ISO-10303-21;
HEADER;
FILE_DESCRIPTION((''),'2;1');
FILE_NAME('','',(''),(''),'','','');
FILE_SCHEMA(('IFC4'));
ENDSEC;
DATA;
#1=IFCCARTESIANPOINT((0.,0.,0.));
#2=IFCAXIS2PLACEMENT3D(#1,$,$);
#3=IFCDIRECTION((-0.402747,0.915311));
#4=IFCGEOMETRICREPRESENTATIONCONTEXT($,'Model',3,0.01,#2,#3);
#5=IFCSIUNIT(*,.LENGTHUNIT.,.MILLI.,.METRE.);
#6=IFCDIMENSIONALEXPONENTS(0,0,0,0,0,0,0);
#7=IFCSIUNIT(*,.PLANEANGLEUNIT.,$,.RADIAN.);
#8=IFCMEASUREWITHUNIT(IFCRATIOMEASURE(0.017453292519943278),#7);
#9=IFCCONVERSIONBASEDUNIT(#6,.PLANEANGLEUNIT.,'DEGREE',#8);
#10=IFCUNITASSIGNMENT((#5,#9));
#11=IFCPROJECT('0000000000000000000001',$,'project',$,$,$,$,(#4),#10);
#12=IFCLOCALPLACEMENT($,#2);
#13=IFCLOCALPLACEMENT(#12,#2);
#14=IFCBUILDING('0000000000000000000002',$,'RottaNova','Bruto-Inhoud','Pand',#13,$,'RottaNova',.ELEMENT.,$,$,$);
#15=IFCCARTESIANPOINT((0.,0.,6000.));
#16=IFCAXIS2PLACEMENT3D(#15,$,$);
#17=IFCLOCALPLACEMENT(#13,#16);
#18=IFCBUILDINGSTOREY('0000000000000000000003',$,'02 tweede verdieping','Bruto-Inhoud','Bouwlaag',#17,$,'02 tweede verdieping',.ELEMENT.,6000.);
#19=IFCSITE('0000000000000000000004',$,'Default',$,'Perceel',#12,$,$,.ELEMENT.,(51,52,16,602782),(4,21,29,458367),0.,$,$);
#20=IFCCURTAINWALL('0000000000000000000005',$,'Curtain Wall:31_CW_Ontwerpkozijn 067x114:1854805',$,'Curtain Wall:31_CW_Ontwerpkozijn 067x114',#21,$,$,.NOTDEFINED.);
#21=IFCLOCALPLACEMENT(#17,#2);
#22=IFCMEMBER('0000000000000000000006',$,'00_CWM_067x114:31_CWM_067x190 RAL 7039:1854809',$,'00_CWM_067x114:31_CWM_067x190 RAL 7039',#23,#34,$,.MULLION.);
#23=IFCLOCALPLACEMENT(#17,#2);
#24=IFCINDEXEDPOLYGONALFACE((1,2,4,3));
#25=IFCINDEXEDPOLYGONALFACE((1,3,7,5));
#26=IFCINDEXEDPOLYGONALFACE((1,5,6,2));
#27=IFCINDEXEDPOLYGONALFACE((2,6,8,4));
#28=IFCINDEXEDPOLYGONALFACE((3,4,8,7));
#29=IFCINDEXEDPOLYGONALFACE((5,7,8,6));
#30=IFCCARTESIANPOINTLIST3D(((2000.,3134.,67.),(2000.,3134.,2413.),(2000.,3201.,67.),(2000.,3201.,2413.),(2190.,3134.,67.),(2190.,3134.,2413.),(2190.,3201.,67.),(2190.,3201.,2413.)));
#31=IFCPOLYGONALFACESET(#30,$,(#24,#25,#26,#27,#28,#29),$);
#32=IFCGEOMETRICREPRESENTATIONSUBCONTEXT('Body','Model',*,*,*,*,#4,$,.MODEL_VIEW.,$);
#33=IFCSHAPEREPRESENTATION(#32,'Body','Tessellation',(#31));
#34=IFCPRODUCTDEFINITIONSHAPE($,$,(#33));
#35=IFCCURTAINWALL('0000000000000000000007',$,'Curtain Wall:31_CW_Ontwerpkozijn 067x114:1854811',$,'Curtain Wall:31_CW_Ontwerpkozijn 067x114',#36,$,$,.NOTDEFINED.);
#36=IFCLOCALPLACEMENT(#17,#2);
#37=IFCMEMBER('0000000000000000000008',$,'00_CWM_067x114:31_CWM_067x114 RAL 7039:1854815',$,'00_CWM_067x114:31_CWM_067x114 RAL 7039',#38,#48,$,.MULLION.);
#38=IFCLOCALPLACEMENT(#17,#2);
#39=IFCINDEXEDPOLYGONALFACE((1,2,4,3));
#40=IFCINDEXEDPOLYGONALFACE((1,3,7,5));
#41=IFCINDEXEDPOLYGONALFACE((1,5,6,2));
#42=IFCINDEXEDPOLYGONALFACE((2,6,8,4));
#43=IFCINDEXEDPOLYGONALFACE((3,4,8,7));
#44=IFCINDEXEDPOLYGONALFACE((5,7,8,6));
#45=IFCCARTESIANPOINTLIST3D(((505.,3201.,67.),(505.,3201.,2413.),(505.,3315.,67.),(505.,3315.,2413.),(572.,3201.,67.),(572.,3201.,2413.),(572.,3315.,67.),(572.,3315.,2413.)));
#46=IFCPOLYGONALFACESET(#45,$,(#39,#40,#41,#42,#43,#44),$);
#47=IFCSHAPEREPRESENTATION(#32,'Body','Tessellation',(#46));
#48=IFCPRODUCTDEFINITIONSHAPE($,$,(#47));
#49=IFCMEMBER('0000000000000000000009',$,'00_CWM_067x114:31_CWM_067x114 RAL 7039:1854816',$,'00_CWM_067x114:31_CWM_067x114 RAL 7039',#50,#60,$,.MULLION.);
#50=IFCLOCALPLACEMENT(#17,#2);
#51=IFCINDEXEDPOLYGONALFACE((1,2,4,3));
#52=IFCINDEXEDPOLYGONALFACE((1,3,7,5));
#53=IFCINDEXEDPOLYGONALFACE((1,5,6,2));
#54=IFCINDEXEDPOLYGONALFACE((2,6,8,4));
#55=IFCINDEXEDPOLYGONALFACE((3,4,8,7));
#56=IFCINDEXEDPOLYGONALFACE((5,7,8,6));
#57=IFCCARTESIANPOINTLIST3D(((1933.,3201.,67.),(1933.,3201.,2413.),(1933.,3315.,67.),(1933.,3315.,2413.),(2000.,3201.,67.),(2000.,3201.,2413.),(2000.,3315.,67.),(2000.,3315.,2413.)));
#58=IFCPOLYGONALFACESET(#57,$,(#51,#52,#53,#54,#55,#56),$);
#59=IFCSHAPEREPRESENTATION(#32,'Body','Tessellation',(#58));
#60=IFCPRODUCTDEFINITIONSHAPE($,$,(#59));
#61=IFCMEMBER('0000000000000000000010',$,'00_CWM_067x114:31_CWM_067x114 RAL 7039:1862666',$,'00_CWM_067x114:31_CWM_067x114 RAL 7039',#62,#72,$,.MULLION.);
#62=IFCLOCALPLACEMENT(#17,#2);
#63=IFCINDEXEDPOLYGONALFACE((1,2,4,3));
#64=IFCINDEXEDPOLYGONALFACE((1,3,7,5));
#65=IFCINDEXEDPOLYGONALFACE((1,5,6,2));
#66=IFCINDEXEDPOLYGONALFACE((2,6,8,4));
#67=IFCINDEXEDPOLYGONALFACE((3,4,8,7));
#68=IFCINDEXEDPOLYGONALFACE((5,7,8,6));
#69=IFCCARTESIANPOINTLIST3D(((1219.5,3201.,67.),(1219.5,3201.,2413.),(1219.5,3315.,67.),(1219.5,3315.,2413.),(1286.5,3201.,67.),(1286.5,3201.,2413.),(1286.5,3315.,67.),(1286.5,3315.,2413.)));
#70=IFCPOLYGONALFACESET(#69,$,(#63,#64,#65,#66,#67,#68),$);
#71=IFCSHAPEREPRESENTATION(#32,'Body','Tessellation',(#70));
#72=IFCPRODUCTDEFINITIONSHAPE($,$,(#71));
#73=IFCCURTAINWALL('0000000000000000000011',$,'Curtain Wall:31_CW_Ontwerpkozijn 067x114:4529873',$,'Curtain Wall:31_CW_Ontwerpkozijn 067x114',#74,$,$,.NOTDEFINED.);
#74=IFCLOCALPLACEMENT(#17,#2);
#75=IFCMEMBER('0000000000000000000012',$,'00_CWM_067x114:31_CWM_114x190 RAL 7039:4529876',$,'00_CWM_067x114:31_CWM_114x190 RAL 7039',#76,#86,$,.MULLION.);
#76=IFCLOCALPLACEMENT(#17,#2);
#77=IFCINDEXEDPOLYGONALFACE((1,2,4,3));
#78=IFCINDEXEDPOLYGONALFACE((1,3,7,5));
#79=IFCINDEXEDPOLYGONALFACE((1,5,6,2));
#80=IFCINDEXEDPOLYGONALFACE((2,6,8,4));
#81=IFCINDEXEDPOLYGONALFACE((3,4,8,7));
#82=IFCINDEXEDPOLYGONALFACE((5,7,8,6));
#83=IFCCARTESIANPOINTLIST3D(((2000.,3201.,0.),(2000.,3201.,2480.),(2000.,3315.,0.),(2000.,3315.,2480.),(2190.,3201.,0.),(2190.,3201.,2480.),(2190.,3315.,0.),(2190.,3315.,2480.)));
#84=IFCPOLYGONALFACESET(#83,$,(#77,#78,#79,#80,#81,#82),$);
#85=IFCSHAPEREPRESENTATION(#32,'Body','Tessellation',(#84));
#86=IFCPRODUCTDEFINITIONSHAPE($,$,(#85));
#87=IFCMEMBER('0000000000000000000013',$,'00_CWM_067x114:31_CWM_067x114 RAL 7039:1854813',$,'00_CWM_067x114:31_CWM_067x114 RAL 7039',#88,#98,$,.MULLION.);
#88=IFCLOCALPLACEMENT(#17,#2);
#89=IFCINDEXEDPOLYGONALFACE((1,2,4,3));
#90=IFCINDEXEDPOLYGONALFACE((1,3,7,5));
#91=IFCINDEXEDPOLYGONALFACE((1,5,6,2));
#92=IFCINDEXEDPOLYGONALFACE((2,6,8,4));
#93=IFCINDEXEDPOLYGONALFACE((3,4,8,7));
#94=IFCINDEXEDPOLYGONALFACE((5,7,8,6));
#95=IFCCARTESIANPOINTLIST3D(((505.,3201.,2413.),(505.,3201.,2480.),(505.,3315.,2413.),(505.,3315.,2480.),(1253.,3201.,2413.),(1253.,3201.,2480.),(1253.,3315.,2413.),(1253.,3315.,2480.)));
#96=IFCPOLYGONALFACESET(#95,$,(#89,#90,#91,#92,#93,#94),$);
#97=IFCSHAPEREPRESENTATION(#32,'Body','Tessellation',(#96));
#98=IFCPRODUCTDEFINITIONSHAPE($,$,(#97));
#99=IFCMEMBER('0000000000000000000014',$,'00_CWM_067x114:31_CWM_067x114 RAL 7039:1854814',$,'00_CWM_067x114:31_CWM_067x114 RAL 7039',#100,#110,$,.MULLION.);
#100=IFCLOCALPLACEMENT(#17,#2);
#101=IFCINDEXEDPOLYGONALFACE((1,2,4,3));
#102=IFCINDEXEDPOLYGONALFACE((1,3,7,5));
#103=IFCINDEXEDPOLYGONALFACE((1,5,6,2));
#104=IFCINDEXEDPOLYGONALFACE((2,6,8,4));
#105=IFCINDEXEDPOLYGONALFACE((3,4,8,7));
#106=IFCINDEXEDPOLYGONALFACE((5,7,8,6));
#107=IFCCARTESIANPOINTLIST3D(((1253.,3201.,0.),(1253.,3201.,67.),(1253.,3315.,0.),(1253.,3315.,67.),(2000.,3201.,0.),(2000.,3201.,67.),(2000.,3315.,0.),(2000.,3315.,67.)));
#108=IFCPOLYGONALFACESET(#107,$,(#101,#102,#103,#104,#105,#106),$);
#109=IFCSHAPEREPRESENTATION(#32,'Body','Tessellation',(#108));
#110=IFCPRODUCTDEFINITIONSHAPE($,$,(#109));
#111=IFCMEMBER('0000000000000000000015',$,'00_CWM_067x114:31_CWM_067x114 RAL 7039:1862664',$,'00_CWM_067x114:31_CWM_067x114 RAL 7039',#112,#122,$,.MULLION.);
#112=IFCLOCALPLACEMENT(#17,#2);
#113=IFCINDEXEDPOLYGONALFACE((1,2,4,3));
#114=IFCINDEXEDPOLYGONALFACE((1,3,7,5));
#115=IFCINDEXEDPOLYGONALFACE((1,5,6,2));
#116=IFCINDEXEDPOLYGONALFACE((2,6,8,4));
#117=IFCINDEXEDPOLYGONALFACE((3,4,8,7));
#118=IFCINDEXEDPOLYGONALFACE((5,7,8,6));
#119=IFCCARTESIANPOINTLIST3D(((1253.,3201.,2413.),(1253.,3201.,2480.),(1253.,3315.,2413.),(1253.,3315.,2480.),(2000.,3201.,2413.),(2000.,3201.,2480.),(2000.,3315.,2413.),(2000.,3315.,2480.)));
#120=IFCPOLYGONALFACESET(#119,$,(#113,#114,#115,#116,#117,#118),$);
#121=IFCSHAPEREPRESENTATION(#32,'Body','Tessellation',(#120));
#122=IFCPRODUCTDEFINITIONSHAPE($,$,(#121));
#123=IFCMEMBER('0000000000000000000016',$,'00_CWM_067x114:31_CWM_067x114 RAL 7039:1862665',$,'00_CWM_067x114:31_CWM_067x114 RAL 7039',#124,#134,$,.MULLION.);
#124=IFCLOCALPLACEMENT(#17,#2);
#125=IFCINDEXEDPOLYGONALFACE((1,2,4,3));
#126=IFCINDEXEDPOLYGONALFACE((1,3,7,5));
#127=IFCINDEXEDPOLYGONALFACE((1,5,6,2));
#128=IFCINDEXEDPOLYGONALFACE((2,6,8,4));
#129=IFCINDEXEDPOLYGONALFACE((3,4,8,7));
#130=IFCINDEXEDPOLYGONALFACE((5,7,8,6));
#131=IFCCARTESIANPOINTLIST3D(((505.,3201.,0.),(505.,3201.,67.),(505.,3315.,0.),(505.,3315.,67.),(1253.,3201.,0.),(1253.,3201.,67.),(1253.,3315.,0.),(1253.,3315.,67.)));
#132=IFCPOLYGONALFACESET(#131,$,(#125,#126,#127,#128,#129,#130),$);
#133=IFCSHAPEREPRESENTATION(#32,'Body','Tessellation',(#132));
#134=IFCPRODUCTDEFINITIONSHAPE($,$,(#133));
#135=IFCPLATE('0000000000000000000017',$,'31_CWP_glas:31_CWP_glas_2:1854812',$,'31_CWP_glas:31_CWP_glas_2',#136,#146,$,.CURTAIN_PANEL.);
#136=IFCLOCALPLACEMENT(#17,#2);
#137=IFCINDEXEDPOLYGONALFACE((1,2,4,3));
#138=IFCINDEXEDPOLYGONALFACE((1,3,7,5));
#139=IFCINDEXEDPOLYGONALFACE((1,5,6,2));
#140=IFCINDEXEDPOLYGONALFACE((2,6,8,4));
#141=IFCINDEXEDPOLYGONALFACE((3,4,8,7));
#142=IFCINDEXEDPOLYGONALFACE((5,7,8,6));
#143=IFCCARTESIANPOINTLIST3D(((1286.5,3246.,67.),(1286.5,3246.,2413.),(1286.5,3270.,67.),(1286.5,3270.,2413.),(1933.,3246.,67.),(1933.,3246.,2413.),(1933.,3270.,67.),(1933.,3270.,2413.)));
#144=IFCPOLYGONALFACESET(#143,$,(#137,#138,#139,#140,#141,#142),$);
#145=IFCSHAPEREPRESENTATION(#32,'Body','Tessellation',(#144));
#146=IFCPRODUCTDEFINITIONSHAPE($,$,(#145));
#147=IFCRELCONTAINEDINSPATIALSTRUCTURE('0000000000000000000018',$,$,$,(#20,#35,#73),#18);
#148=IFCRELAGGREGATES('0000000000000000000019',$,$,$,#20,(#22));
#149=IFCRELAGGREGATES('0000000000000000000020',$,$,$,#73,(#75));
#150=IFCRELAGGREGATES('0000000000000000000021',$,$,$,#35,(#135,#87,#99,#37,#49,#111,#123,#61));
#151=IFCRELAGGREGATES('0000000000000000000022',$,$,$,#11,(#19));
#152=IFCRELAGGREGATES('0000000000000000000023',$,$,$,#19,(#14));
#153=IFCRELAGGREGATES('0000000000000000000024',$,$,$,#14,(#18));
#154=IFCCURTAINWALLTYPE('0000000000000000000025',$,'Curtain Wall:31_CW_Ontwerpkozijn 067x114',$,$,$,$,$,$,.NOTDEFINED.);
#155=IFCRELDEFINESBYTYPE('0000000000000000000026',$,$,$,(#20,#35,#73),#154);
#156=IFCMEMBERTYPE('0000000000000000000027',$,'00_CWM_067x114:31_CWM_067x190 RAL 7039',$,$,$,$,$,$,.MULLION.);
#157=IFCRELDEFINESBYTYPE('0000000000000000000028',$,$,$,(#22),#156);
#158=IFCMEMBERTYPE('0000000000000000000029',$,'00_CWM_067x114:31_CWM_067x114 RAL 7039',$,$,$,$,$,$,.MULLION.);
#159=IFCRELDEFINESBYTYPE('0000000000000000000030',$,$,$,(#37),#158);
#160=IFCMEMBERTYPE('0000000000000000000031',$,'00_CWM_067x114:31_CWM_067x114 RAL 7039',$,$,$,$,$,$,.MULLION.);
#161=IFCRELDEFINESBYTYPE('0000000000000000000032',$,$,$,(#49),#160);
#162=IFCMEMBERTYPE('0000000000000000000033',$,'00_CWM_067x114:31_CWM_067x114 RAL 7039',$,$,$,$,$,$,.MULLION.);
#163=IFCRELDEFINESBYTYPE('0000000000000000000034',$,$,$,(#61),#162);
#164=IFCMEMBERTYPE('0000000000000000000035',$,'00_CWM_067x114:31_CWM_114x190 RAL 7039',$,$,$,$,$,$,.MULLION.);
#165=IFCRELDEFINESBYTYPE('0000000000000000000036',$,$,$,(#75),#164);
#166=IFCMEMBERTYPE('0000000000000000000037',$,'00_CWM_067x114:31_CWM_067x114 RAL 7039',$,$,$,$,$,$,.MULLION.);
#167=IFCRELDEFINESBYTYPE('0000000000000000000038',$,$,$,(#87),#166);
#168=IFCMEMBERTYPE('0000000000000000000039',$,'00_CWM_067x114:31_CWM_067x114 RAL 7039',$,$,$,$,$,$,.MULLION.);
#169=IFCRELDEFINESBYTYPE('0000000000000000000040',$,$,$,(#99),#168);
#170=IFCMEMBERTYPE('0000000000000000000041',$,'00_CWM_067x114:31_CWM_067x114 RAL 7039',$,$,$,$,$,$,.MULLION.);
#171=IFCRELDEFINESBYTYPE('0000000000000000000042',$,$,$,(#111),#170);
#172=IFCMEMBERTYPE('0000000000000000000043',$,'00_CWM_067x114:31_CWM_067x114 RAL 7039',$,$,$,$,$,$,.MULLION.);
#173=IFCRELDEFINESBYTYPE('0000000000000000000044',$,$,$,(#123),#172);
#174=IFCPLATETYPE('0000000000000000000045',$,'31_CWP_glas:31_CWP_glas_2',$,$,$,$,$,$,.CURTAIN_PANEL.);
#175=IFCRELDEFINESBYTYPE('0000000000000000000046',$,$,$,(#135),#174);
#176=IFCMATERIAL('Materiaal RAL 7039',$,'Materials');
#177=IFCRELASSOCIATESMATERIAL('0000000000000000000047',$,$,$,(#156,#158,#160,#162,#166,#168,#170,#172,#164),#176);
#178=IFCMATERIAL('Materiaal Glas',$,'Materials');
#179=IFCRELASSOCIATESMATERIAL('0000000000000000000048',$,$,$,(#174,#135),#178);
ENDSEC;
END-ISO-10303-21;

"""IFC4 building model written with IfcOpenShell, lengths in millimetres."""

from ifc_helpers import new_model, entity, si_unit, converted_unit, direction, frame, frame_2d, origin, origin_2d_with_axis, place, context, subcontext, project, spatial, rectangle, extrude, source, transform, mapped, material, material_profile, profile_set, type_object, type_shapes, element, aggregate, save


model = new_model("IFC4")

# Units and contexts
model_context = context("Model", 3, precision=0.01, world=origin(), true_north=direction((-0.402747, 0.915311)))
body_context = subcontext(model_context, "Body", "Model", "MODEL_VIEW")
ifc_project = project(units=[si_unit("LENGTHUNIT", "METRE", prefix="MILLI"), converted_unit("PLANEANGLEUNIT", "DEGREE", entity("IfcRatioMeasure", 0.017453292519943278), si_unit("PLANEANGLEUNIT", "RADIAN"), dimensions=[0, 0, 0, 0, 0, 0, 0])], contexts=[model_context])

# Site, building, storey
site_placement = place(None, origin())
site = spatial("IfcSite", under=ifc_project, at=site_placement, Name="Default", ObjectType="Perceel", CompositionType="ELEMENT", RefLatitude=(51, 52, 16, 602782), RefLongitude=(4, 21, 29, 458367), RefElevation=0.0)
building_placement = place(site_placement, origin())
building = spatial("IfcBuilding", under=site, at=building_placement, Name="RottaNova", Description="Bruto-Inhoud", ObjectType="Pand", LongName="RottaNova", CompositionType="ELEMENT")
storey_placement = place(building_placement, frame((0.0, 0.0, 6000.0)))
storey = spatial("IfcBuildingStorey", under=building, at=storey_placement, Name="02 tweede verdieping", Description="Bruto-Inhoud", ObjectType="Bouwlaag", LongName="02 tweede verdieping", CompositionType="ELEMENT", Elevation=6000.0)

# Curtain wall, member
curtain_wall_type = type_object("IfcCurtainWallType", Name="Curtain Wall:31_CW_Ontwerpkozijn 067x114", PredefinedType="NOTDEFINED")
curtain_wall_1_placement = place(storey_placement, frame((0.0, 0.0, -6000.0)))
curtain_wall_1 = element("IfcCurtainWall", 1, at=curtain_wall_1_placement, inside=storey, type_object=curtain_wall_type, Name="Curtain Wall:31_CW_Ontwerpkozijn 067x114:1854805", ObjectType="Curtain Wall:31_CW_Ontwerpkozijn 067x114", PredefinedType="NOTDEFINED")
ifc_material_1 = material(Name="Materiaal RAL 7039", Category="Materials")
ifc_material_profile_1 = material_profile(ifc_material_1, rectangle(XDim=190.0, YDim=67.0, at=origin_2d_with_axis()), Name="31_CWM_067x190 RAL 7039")
ifc_profile_set_1 = profile_set([ifc_material_profile_1], Name="31_CWM_067x190 RAL 7039")
member_type_1 = type_object("IfcMemberType", Name="00_CWM_067x114:31_CWM_067x190 RAL 7039", PredefinedType="MULLION", material=ifc_profile_set_1)
shared_shape_1 = source(origin(), body_context, "Body", "SweptSolid", [
    extrude(rectangle(XDim=190.0, YDim=67.0, at=origin_2d_with_axis()), frame((-33.5, -95.0, -2346.0), z_axis=(0.0, 0.0, 1.0), x_axis=(0.0, -1.0, 0.0)), (0.0, 0.0, 1.0), 2346.0),
])
type_shapes(member_type_1, [shared_shape_1])
member_1_placement = place(curtain_wall_1_placement, frame((2190.0, 3201.0, 6067.0), z_axis=(0.0, 0.0, -1.0), x_axis=(0.0, 1.0, 0.0)))
member_1 = element("IfcMember", 2, at=member_1_placement, type_object=member_type_1, Name="00_CWM_067x114:31_CWM_067x190 RAL 7039:1854809", ObjectType="00_CWM_067x114:31_CWM_067x190 RAL 7039", PredefinedType="MULLION", context=body_context, shape_type="MappedRepresentation", body=[
    mapped(shared_shape_1, transform((0.0, 0.0, 0.0), scale=1.0)),
])
aggregate(curtain_wall_1, [member_1])

# Curtain wall, members
curtain_wall_2_placement = place(storey_placement, frame((0.0, 0.0, -6000.0)))
curtain_wall_2 = element("IfcCurtainWall", 3, at=curtain_wall_2_placement, inside=storey, type_object=curtain_wall_type, Name="Curtain Wall:31_CW_Ontwerpkozijn 067x114:1854811", ObjectType="Curtain Wall:31_CW_Ontwerpkozijn 067x114", PredefinedType="NOTDEFINED")
ifc_material_profile_2 = material_profile(ifc_material_1, rectangle(XDim=114.0, YDim=67.0, at=origin_2d_with_axis()), Name="31_CWM_067x114 RAL 7039")
ifc_profile_set_2 = profile_set([ifc_material_profile_2], Name="31_CWM_067x114 RAL 7039")
member_type_2 = type_object("IfcMemberType", Name="00_CWM_067x114:31_CWM_067x114 RAL 7039", PredefinedType="MULLION", material=ifc_profile_set_2)
shared_shape_2 = source(origin(), body_context, "Body", "SweptSolid", [
    extrude(rectangle(XDim=114.0, YDim=67.0, at=frame_2d((0.0, 0.0), x_axis=(1.0, 0.0))), frame((-33.5, -57.0, -2346.0), z_axis=(0.0, 0.0, 1.0), x_axis=(0.0, -1.0, 0.0)), (0.0, 0.0, 1.0), 2346.0),
])
type_shapes(member_type_2, [shared_shape_2])
member_2_placement = place(curtain_wall_2_placement, frame((505.0, 3315.0, 6067.0), z_axis=(0.0, 0.0, -1.0), x_axis=(-1.0, 0.0, 0.0)))
member_2 = element("IfcMember", 4, at=member_2_placement, type_object=member_type_2, Name="00_CWM_067x114:31_CWM_067x114 RAL 7039:1854815", ObjectType="00_CWM_067x114:31_CWM_067x114 RAL 7039", PredefinedType="MULLION", context=body_context, shape_type="MappedRepresentation", body=[
    mapped(shared_shape_2, transform((0.0, 0.0, 0.0), scale=1.0)),
])
member_type_3 = type_object("IfcMemberType", Name="00_CWM_067x114:31_CWM_067x114 RAL 7039", PredefinedType="MULLION", material=ifc_profile_set_2)
shared_shape_3 = source(origin(), body_context, "Body", "SweptSolid", [
    extrude(rectangle(XDim=114.0, YDim=67.0, at=frame_2d((0.0, 0.0), x_axis=(1.0, 0.0))), frame((-33.5, -57.0, -2346.0), z_axis=(0.0, 0.0, 1.0), x_axis=(0.0, -1.0, 0.0)), (0.0, 0.0, 1.0), 2346.0),
])
type_shapes(member_type_3, [shared_shape_3])
member_3_placement = place(curtain_wall_2_placement, frame((2000.0, 3315.0, 8413.0)))
member_3 = element("IfcMember", 5, at=member_3_placement, type_object=member_type_3, Name="00_CWM_067x114:31_CWM_067x114 RAL 7039:1854816", ObjectType="00_CWM_067x114:31_CWM_067x114 RAL 7039", PredefinedType="MULLION", context=body_context, shape_type="MappedRepresentation", body=[
    mapped(shared_shape_3, transform((0.0, 0.0, 0.0), scale=1.0)),
])
member_type_4 = type_object("IfcMemberType", Name="00_CWM_067x114:31_CWM_067x114 RAL 7039", PredefinedType="MULLION", material=ifc_profile_set_2)
shared_shape_4 = source(origin(), body_context, "Body", "SweptSolid", [
    extrude(rectangle(XDim=114.0, YDim=67.0, at=frame_2d((0.0, 0.0), x_axis=(1.0, 0.0))), frame((0.0, -57.0, -2346.0), z_axis=(0.0, 0.0, 1.0), x_axis=(0.0, -1.0, 0.0)), (0.0, 0.0, 1.0), 2346.0),
])
type_shapes(member_type_4, [shared_shape_4])
member_4_placement = place(curtain_wall_2_placement, frame((1253.0, 3315.0, 6067.0), z_axis=(0.0, 0.0, -1.0), x_axis=(-1.0, 0.0, 0.0)))
member_4 = element("IfcMember", 6, at=member_4_placement, type_object=member_type_4, Name="00_CWM_067x114:31_CWM_067x114 RAL 7039:1862666", ObjectType="00_CWM_067x114:31_CWM_067x114 RAL 7039", PredefinedType="MULLION", context=body_context, shape_type="MappedRepresentation", body=[
    mapped(shared_shape_4, transform((0.0, 0.0, 0.0), scale=1.0)),
])

# Curtain wall, member
curtain_wall_3_placement = place(storey_placement, frame((0.0, 0.0, -6000.0)))
curtain_wall_3 = element("IfcCurtainWall", 7, at=curtain_wall_3_placement, inside=storey, type_object=curtain_wall_type, Name="Curtain Wall:31_CW_Ontwerpkozijn 067x114:4529873", ObjectType="Curtain Wall:31_CW_Ontwerpkozijn 067x114", PredefinedType="NOTDEFINED")
ifc_material_profile_3 = material_profile(ifc_material_1, rectangle(XDim=114.0, YDim=190.0, at=origin_2d_with_axis()), Name="31_CWM_114x190 RAL 7039")
ifc_profile_set_3 = profile_set([ifc_material_profile_3], Name="31_CWM_114x190 RAL 7039")
member_type_5 = type_object("IfcMemberType", Name="00_CWM_067x114:31_CWM_114x190 RAL 7039", PredefinedType="MULLION", material=ifc_profile_set_3)
shared_shape_5 = source(origin(), body_context, "Body", "SweptSolid", [
    extrude(rectangle(XDim=114.0, YDim=190.0, at=origin_2d_with_axis()), frame((-95.0, 0.0, -2480.0), z_axis=(0.0, 0.0, 1.0), x_axis=(0.0, -1.0, 0.0)), (0.0, 0.0, 1.0), 2480.0),
])
type_shapes(member_type_5, [shared_shape_5])
member_5_placement = place(curtain_wall_3_placement, frame((2190.0, 3258.0, 8480.0)))
member_5 = element("IfcMember", 8, at=member_5_placement, type_object=member_type_5, Name="00_CWM_067x114:31_CWM_114x190 RAL 7039:4529876", ObjectType="00_CWM_067x114:31_CWM_114x190 RAL 7039", PredefinedType="MULLION", context=body_context, shape_type="MappedRepresentation", body=[
    mapped(shared_shape_5, transform((0.0, 0.0, 0.0), scale=1.0)),
])
aggregate(curtain_wall_3, [member_5])

# Members
member_type_6 = type_object("IfcMemberType", Name="00_CWM_067x114:31_CWM_067x114 RAL 7039", PredefinedType="MULLION", material=ifc_profile_set_2)
shared_shape_6 = source(origin(), body_context, "Body", "SweptSolid", [
    extrude(rectangle(XDim=114.0, YDim=67.0, at=frame_2d((0.0, 0.0), x_axis=(1.0, 0.0))), frame((-33.5, -57.0, -748.0), z_axis=(0.0, 0.0, 1.0), x_axis=(0.0, -1.0, 0.0)), (0.0, 0.0, 1.0), 748.0),
])
type_shapes(member_type_6, [shared_shape_6])
member_6_placement = place(curtain_wall_2_placement, frame((505.0, 3315.0, 8480.0), z_axis=(-1.0, 0.0, 0.0), x_axis=(0.0, 0.0, 1.0)))
member_6 = element("IfcMember", 9, at=member_6_placement, type_object=member_type_6, Name="00_CWM_067x114:31_CWM_067x114 RAL 7039:1854813", ObjectType="00_CWM_067x114:31_CWM_067x114 RAL 7039", PredefinedType="MULLION", context=body_context, shape_type="MappedRepresentation", body=[
    mapped(shared_shape_6, transform((0.0, 0.0, 0.0), scale=1.0)),
])
member_type_7 = type_object("IfcMemberType", Name="00_CWM_067x114:31_CWM_067x114 RAL 7039", PredefinedType="MULLION", material=ifc_profile_set_2)
shared_shape_7 = source(origin(), body_context, "Body", "SweptSolid", [
    extrude(rectangle(XDim=114.0, YDim=67.0, at=frame_2d((0.0, 0.0), x_axis=(1.0, 0.0))), frame((-33.5, -57.0, -747.0), z_axis=(0.0, 0.0, 1.0), x_axis=(0.0, -1.0, 0.0)), (0.0, 0.0, 1.0), 747.0),
])
type_shapes(member_type_7, [shared_shape_7])
member_7_placement = place(curtain_wall_2_placement, frame((2000.0, 3315.0, 6000.0), z_axis=(1.0, 0.0, 0.0), x_axis=(0.0, 0.0, -1.0)))
member_7 = element("IfcMember", 10, at=member_7_placement, type_object=member_type_7, Name="00_CWM_067x114:31_CWM_067x114 RAL 7039:1854814", ObjectType="00_CWM_067x114:31_CWM_067x114 RAL 7039", PredefinedType="MULLION", context=body_context, shape_type="MappedRepresentation", body=[
    mapped(shared_shape_7, transform((0.0, 0.0, 0.0), scale=1.0)),
])
member_type_8 = type_object("IfcMemberType", Name="00_CWM_067x114:31_CWM_067x114 RAL 7039", PredefinedType="MULLION", material=ifc_profile_set_2)
shared_shape_8 = source(origin(), body_context, "Body", "SweptSolid", [
    extrude(rectangle(XDim=114.0, YDim=67.0, at=frame_2d((0.0, 0.0), x_axis=(1.0, 0.0))), frame((-33.5, -57.0, -747.0), z_axis=(0.0, 0.0, 1.0), x_axis=(0.0, -1.0, 0.0)), (0.0, 0.0, 1.0), 747.0),
])
type_shapes(member_type_8, [shared_shape_8])
member_8_placement = place(curtain_wall_2_placement, frame((1253.0, 3315.0, 8480.0), z_axis=(-1.0, 0.0, 0.0), x_axis=(0.0, 0.0, 1.0)))
member_8 = element("IfcMember", 11, at=member_8_placement, type_object=member_type_8, Name="00_CWM_067x114:31_CWM_067x114 RAL 7039:1862664", ObjectType="00_CWM_067x114:31_CWM_067x114 RAL 7039", PredefinedType="MULLION", context=body_context, shape_type="MappedRepresentation", body=[
    mapped(shared_shape_8, transform((0.0, 0.0, 0.0), scale=1.0)),
])
member_type_9 = type_object("IfcMemberType", Name="00_CWM_067x114:31_CWM_067x114 RAL 7039", PredefinedType="MULLION", material=ifc_profile_set_2)
shared_shape_9 = source(origin(), body_context, "Body", "SweptSolid", [
    extrude(rectangle(XDim=114.0, YDim=67.0, at=frame_2d((0.0, 0.0), x_axis=(1.0, 0.0))), frame((-33.5, -57.0, -748.0), z_axis=(0.0, 0.0, 1.0), x_axis=(0.0, -1.0, 0.0)), (0.0, 0.0, 1.0), 748.0),
])
type_shapes(member_type_9, [shared_shape_9])
member_9_placement = place(curtain_wall_2_placement, frame((1253.0, 3315.0, 6000.0), z_axis=(1.0, 0.0, 0.0), x_axis=(0.0, 0.0, -1.0)))
member_9 = element("IfcMember", 12, at=member_9_placement, type_object=member_type_9, Name="00_CWM_067x114:31_CWM_067x114 RAL 7039:1862665", ObjectType="00_CWM_067x114:31_CWM_067x114 RAL 7039", PredefinedType="MULLION", context=body_context, shape_type="MappedRepresentation", body=[
    mapped(shared_shape_9, transform((0.0, 0.0, 0.0), scale=1.0)),
])

# Plate
ifc_material_2 = material(Name="Materiaal Glas", Category="Materials")
plate_type_1 = type_object("IfcPlateType", Name="31_CWP_glas:31_CWP_glas_2", PredefinedType="CURTAIN_PANEL", material=ifc_material_2)
shared_shape_10 = source(origin(), body_context, "Body", "SweptSolid", [
    extrude(rectangle(XDim=24.0, YDim=646.5, at=frame_2d((0.0, 0.0), x_axis=(1.0, 0.0))), frame((323.2, 12.0, 0.0), z_axis=(0.0, 0.0, 1.0), x_axis=(0.0, 1.0, 0.0)), (0.0, 0.0, 1.0), 2346.0),
])
type_shapes(plate_type_1, [shared_shape_10])
plate_1_placement = place(curtain_wall_2_placement, frame((1933.0, 3270.0, 6067.0), z_axis=(0.0, 0.0, 1.0), x_axis=(-1.0, 0.0, 0.0)))
plate_1 = element("IfcPlate", 13, at=plate_1_placement, type_object=plate_type_1, material=ifc_material_2, Name="31_CWP_glas:31_CWP_glas_2:1854812", ObjectType="31_CWP_glas:31_CWP_glas_2", PredefinedType="CURTAIN_PANEL", context=body_context, shape_type="MappedRepresentation", body=[
    mapped(shared_shape_10, transform((0.0, 0.0, 0.0), scale=1.0)),
])
aggregate(curtain_wall_2, [plate_1, member_6, member_7, member_2, member_3, member_8, member_9, member_4])

save(model, "model.ifc")
